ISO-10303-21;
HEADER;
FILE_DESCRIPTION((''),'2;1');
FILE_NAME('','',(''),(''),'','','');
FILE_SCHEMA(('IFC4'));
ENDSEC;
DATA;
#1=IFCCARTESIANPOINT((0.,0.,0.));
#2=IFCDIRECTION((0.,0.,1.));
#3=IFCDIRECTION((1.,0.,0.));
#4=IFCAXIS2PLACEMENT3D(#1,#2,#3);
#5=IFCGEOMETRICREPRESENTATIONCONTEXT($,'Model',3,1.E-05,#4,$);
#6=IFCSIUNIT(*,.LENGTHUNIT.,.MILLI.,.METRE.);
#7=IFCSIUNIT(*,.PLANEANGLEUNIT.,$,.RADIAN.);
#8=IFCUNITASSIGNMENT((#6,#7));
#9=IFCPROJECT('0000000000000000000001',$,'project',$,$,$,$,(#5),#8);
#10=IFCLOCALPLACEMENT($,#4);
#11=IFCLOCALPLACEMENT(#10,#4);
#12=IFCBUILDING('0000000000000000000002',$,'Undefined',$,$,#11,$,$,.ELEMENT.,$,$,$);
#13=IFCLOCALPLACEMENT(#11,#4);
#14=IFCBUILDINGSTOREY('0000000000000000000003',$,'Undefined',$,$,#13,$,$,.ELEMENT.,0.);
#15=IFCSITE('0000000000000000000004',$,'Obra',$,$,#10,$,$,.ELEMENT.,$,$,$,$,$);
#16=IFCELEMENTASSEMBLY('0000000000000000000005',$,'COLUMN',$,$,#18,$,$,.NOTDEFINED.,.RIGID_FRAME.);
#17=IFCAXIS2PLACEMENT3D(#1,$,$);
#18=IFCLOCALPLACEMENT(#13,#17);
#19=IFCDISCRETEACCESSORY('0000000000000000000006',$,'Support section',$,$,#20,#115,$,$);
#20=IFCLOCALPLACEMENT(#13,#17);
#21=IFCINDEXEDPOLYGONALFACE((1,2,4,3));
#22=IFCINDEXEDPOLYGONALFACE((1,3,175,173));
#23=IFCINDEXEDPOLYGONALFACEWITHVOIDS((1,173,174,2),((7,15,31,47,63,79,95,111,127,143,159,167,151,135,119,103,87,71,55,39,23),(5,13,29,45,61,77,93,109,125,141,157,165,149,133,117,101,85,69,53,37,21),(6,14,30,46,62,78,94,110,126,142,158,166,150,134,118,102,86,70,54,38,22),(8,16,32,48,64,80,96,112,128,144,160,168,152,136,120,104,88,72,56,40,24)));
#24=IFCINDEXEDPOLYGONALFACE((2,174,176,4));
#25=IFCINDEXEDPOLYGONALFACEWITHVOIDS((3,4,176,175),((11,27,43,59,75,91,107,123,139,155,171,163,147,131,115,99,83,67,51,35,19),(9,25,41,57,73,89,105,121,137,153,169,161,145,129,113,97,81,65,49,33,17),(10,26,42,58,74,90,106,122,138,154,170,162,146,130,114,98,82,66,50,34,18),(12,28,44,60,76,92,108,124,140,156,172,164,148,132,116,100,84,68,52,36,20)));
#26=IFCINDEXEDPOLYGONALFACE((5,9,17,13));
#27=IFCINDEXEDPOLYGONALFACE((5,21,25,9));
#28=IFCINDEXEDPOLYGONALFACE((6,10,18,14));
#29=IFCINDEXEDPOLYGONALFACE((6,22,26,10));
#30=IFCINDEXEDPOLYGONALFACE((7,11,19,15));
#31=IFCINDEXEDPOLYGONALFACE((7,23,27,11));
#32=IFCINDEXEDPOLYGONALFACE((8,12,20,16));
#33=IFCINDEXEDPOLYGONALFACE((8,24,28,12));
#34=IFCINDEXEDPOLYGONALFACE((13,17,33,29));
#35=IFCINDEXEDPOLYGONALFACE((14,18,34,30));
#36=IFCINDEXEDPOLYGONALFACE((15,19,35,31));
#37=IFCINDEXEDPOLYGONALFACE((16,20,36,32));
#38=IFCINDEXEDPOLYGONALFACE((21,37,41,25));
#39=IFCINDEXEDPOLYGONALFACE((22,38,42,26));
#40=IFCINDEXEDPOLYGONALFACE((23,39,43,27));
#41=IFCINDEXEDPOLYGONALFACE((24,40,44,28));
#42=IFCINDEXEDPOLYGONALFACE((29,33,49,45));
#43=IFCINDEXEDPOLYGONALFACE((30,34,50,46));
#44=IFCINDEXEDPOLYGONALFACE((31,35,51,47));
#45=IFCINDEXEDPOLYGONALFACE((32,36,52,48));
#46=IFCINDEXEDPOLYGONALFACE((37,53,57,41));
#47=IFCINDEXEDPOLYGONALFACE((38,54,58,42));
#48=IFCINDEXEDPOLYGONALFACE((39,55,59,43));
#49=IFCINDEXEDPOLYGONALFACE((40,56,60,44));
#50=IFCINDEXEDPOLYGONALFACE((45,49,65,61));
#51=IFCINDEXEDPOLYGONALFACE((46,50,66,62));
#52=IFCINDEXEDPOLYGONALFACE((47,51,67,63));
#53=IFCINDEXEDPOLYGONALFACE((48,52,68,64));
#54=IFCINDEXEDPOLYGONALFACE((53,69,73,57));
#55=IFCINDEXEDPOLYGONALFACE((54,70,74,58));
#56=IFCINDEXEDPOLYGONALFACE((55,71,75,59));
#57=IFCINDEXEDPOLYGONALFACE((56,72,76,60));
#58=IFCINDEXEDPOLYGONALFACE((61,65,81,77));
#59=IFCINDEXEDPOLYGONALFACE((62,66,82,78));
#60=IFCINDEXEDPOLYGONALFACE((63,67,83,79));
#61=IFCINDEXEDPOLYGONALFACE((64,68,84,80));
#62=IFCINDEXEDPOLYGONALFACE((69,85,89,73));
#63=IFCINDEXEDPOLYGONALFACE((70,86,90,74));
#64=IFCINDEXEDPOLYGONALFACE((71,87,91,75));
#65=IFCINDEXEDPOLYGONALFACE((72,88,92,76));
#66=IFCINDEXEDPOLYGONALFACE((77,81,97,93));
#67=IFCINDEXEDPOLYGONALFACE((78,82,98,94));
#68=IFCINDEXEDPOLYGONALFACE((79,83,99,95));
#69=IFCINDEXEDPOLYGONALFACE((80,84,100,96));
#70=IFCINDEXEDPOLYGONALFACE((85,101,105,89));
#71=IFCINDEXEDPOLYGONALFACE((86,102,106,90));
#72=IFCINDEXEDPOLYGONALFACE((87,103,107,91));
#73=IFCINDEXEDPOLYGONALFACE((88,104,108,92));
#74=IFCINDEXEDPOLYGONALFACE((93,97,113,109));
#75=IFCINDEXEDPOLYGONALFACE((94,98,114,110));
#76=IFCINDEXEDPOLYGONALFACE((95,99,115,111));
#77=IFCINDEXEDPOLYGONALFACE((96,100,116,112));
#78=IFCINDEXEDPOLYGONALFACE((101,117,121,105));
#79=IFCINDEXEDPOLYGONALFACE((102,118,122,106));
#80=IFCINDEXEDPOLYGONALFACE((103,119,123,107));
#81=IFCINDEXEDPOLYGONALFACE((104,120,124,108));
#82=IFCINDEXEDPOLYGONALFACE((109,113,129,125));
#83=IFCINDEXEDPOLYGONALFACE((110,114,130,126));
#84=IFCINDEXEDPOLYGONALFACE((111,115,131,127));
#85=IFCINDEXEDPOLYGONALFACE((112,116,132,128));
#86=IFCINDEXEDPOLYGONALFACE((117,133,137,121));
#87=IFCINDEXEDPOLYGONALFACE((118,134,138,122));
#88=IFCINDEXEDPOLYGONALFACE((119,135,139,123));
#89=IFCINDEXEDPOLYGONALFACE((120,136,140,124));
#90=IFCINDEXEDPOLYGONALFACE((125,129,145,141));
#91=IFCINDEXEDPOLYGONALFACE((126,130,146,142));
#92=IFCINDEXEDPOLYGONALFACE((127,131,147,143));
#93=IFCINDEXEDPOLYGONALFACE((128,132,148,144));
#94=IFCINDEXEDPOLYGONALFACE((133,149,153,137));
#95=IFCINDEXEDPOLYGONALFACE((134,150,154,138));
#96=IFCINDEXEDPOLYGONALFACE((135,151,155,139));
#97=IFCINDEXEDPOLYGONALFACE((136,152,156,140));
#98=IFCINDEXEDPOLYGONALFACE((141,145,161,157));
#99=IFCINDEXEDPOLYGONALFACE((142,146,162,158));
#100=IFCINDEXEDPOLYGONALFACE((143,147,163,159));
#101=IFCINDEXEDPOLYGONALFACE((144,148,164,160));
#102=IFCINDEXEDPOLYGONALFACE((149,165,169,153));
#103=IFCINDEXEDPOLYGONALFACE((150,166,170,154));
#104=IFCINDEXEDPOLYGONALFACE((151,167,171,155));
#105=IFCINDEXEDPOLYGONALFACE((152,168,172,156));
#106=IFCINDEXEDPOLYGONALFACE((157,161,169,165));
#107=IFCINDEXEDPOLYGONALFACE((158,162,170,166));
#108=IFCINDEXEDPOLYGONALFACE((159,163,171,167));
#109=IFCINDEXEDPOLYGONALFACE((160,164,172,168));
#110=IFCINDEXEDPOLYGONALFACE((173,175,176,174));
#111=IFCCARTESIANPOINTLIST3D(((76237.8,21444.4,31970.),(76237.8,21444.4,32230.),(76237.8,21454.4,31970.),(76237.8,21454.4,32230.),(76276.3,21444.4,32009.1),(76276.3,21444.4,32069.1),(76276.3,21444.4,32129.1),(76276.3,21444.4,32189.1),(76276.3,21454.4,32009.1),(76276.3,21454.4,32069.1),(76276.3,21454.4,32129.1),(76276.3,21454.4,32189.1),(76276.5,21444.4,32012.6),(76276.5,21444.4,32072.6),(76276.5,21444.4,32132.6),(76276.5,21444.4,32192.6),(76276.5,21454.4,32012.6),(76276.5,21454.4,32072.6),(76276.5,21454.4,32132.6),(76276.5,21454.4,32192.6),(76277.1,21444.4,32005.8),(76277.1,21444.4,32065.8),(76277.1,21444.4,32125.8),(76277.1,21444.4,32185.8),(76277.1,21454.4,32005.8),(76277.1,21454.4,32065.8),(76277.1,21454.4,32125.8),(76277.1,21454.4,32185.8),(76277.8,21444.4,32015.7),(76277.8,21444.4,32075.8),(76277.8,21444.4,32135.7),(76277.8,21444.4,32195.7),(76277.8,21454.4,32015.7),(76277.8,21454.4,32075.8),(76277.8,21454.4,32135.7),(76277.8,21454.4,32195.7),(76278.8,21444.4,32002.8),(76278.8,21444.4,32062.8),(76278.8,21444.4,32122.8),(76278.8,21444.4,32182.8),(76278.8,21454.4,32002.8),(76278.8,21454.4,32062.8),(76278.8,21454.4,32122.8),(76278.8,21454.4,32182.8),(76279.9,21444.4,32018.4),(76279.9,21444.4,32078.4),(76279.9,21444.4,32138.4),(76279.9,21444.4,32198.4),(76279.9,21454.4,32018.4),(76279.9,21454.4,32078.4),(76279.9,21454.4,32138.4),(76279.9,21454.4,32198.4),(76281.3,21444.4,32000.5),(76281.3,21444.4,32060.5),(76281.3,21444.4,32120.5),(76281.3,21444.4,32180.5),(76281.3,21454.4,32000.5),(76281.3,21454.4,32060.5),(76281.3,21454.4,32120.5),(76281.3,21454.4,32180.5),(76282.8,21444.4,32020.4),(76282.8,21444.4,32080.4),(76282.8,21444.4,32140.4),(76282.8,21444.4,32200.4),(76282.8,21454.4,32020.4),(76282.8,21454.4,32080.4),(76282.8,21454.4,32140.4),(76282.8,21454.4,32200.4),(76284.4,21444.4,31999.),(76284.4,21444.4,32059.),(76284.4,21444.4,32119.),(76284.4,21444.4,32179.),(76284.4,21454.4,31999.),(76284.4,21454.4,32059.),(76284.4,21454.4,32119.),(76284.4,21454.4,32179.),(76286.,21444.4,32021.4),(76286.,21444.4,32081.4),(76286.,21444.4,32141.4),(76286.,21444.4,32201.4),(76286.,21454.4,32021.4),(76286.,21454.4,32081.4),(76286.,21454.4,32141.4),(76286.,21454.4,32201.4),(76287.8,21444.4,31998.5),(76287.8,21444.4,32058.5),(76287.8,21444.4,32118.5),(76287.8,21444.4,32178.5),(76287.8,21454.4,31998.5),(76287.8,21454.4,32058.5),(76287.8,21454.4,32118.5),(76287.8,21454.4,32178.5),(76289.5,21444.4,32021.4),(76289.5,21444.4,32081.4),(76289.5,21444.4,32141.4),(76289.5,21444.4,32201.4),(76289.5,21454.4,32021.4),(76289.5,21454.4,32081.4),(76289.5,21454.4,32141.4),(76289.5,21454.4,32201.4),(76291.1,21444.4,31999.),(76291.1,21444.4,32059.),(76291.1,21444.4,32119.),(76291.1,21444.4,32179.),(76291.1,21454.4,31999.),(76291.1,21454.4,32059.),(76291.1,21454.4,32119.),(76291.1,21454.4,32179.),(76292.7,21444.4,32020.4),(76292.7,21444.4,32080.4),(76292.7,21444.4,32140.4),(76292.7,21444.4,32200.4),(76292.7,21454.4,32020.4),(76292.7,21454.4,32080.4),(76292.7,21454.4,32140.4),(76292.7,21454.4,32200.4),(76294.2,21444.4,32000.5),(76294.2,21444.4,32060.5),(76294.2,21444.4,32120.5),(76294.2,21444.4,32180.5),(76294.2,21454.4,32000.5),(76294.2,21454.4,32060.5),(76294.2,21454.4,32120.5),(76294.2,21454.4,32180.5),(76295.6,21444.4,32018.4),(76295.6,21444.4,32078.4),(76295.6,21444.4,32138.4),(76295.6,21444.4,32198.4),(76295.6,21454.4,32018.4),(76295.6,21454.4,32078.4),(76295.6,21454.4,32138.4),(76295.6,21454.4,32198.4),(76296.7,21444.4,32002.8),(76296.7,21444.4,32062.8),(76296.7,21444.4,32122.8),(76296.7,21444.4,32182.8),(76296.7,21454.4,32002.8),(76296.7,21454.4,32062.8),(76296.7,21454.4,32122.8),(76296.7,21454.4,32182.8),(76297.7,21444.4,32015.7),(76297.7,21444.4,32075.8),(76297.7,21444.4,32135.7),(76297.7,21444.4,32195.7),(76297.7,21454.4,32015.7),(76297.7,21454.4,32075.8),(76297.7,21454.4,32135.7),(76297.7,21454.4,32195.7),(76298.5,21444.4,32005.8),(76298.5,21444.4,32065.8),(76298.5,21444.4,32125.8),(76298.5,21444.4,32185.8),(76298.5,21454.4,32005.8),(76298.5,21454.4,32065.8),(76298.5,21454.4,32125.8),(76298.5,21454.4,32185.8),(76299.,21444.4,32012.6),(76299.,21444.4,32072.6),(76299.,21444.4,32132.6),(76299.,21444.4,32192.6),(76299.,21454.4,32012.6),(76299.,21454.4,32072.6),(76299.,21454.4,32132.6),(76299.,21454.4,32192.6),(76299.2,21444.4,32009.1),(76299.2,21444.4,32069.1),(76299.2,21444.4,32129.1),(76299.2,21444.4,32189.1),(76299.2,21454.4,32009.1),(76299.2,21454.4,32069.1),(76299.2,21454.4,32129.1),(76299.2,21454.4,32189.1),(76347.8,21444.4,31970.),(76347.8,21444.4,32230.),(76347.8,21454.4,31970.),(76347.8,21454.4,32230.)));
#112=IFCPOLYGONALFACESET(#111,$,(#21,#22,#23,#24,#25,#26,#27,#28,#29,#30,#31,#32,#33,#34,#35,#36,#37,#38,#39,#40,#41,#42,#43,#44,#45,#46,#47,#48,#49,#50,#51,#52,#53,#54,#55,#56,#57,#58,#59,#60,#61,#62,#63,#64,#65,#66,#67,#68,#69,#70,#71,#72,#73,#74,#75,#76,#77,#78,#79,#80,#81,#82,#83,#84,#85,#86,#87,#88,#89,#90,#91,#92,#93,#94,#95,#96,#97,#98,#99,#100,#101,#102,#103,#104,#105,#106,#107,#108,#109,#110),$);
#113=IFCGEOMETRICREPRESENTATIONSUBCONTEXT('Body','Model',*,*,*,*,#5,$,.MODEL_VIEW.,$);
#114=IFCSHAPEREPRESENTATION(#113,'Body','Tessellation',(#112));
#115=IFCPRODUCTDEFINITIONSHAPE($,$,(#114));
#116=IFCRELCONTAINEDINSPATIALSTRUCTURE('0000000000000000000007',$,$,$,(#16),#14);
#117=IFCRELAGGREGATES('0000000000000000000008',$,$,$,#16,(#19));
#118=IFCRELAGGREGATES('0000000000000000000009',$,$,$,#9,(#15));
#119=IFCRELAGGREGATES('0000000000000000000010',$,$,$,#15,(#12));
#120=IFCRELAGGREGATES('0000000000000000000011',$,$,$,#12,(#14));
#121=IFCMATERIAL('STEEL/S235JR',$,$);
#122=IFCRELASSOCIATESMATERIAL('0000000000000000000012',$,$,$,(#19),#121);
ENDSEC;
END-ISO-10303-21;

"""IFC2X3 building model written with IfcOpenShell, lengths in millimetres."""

from ifc_helpers import new_model, si_unit, frame, origin_with_axes, origin_2d_with_axis, place, context, subcontext, project, spatial, rectangle, circle, extrude, source, transform, mapped, material, element, aggregate, save


model = new_model("IFC2X3")

# Units and contexts
model_context = context("Model", 3, precision=1e-05, world=origin_with_axes())
body_context = subcontext(model_context, "Body", "Model", "MODEL_VIEW")
ifc_project = project(units=[si_unit("LENGTHUNIT", "METRE", prefix="MILLI"), si_unit("PLANEANGLEUNIT", "RADIAN")], contexts=[model_context])

# Site, building, storey
site_placement = place(None, origin_with_axes())
site = spatial("IfcSite", under=ifc_project, at=site_placement, Name="Obra", CompositionType="ELEMENT")
building_placement = place(site_placement, origin_with_axes())
building = spatial("IfcBuilding", under=site, at=building_placement, Name="Undefined", CompositionType="ELEMENT")
storey_placement = place(building_placement, origin_with_axes())
storey = spatial("IfcBuildingStorey", under=building, at=storey_placement, Name="Undefined", CompositionType="ELEMENT", Elevation=0.0)

# Shared definitions
ifc_material_1 = material(Name="STEEL/S235JR")

# Element assembly, discrete accessory, opening
assembly_1_placement = place(storey_placement, origin_with_axes())
assembly_1 = element("IfcElementAssembly", 1, at=assembly_1_placement, inside=storey, Name="COLUMN", AssemblyPlace="NOTDEFINED", PredefinedType="RIGID_FRAME")
shared_shape_1 = source(origin_with_axes(), body_context, "Body", "SweptSolid", [
    extrude(circle(Radius=11.5, at=origin_2d_with_axis()), frame((0.0, -14.4, 0.0), z_axis=(0.0, 1.0, 0.0), x_axis=(1.0, 0.0, 0.0)), (0.0, 0.0, 1.0), 10.2),
])
discrete_accessory_1_placement = place(assembly_1_placement, frame((76292.8, 21449.4, 31970.0), z_axis=(0.0, 0.0, 1.0), x_axis=(1.0, 0.0, 0.0)))
discrete_accessory_1 = element("IfcDiscreteAccessory", 2, at=discrete_accessory_1_placement, material=ifc_material_1, Name="Support section", context=body_context, shape_type="SweptSolid", body=[
    extrude(rectangle(XDim=10.0, YDim=110.0, at=origin_2d_with_axis()), frame((0.0, 0.0, 260.0), z_axis=(0.0, 0.0, -1.0), x_axis=(0.0, 1.0, 0.0)), (0.0, 0.0, 1.0), 260.0),
])
opening_1_placement = place(assembly_1_placement, frame((76337.8, 21440.1, 32300.0), z_axis=(-1.0, 0.0, 0.0), x_axis=(0.0, 0.0, -1.0)))
element("IfcOpeningElement", 3, at=opening_1_placement, cuts=discrete_accessory_1, ObjectType="Opening", context=body_context, shape_type="MappedRepresentation", body=[
    mapped(shared_shape_1, transform((110.0, 0.0, 50.0))),
    mapped(shared_shape_1, transform((170.0, 0.0, 50.0))),
    mapped(shared_shape_1, transform((230.0, 0.0, 50.0))),
    mapped(shared_shape_1, transform((290.0, 0.0, 50.0))),
])
aggregate(assembly_1, [discrete_accessory_1])

save(model, "model.ifc")
